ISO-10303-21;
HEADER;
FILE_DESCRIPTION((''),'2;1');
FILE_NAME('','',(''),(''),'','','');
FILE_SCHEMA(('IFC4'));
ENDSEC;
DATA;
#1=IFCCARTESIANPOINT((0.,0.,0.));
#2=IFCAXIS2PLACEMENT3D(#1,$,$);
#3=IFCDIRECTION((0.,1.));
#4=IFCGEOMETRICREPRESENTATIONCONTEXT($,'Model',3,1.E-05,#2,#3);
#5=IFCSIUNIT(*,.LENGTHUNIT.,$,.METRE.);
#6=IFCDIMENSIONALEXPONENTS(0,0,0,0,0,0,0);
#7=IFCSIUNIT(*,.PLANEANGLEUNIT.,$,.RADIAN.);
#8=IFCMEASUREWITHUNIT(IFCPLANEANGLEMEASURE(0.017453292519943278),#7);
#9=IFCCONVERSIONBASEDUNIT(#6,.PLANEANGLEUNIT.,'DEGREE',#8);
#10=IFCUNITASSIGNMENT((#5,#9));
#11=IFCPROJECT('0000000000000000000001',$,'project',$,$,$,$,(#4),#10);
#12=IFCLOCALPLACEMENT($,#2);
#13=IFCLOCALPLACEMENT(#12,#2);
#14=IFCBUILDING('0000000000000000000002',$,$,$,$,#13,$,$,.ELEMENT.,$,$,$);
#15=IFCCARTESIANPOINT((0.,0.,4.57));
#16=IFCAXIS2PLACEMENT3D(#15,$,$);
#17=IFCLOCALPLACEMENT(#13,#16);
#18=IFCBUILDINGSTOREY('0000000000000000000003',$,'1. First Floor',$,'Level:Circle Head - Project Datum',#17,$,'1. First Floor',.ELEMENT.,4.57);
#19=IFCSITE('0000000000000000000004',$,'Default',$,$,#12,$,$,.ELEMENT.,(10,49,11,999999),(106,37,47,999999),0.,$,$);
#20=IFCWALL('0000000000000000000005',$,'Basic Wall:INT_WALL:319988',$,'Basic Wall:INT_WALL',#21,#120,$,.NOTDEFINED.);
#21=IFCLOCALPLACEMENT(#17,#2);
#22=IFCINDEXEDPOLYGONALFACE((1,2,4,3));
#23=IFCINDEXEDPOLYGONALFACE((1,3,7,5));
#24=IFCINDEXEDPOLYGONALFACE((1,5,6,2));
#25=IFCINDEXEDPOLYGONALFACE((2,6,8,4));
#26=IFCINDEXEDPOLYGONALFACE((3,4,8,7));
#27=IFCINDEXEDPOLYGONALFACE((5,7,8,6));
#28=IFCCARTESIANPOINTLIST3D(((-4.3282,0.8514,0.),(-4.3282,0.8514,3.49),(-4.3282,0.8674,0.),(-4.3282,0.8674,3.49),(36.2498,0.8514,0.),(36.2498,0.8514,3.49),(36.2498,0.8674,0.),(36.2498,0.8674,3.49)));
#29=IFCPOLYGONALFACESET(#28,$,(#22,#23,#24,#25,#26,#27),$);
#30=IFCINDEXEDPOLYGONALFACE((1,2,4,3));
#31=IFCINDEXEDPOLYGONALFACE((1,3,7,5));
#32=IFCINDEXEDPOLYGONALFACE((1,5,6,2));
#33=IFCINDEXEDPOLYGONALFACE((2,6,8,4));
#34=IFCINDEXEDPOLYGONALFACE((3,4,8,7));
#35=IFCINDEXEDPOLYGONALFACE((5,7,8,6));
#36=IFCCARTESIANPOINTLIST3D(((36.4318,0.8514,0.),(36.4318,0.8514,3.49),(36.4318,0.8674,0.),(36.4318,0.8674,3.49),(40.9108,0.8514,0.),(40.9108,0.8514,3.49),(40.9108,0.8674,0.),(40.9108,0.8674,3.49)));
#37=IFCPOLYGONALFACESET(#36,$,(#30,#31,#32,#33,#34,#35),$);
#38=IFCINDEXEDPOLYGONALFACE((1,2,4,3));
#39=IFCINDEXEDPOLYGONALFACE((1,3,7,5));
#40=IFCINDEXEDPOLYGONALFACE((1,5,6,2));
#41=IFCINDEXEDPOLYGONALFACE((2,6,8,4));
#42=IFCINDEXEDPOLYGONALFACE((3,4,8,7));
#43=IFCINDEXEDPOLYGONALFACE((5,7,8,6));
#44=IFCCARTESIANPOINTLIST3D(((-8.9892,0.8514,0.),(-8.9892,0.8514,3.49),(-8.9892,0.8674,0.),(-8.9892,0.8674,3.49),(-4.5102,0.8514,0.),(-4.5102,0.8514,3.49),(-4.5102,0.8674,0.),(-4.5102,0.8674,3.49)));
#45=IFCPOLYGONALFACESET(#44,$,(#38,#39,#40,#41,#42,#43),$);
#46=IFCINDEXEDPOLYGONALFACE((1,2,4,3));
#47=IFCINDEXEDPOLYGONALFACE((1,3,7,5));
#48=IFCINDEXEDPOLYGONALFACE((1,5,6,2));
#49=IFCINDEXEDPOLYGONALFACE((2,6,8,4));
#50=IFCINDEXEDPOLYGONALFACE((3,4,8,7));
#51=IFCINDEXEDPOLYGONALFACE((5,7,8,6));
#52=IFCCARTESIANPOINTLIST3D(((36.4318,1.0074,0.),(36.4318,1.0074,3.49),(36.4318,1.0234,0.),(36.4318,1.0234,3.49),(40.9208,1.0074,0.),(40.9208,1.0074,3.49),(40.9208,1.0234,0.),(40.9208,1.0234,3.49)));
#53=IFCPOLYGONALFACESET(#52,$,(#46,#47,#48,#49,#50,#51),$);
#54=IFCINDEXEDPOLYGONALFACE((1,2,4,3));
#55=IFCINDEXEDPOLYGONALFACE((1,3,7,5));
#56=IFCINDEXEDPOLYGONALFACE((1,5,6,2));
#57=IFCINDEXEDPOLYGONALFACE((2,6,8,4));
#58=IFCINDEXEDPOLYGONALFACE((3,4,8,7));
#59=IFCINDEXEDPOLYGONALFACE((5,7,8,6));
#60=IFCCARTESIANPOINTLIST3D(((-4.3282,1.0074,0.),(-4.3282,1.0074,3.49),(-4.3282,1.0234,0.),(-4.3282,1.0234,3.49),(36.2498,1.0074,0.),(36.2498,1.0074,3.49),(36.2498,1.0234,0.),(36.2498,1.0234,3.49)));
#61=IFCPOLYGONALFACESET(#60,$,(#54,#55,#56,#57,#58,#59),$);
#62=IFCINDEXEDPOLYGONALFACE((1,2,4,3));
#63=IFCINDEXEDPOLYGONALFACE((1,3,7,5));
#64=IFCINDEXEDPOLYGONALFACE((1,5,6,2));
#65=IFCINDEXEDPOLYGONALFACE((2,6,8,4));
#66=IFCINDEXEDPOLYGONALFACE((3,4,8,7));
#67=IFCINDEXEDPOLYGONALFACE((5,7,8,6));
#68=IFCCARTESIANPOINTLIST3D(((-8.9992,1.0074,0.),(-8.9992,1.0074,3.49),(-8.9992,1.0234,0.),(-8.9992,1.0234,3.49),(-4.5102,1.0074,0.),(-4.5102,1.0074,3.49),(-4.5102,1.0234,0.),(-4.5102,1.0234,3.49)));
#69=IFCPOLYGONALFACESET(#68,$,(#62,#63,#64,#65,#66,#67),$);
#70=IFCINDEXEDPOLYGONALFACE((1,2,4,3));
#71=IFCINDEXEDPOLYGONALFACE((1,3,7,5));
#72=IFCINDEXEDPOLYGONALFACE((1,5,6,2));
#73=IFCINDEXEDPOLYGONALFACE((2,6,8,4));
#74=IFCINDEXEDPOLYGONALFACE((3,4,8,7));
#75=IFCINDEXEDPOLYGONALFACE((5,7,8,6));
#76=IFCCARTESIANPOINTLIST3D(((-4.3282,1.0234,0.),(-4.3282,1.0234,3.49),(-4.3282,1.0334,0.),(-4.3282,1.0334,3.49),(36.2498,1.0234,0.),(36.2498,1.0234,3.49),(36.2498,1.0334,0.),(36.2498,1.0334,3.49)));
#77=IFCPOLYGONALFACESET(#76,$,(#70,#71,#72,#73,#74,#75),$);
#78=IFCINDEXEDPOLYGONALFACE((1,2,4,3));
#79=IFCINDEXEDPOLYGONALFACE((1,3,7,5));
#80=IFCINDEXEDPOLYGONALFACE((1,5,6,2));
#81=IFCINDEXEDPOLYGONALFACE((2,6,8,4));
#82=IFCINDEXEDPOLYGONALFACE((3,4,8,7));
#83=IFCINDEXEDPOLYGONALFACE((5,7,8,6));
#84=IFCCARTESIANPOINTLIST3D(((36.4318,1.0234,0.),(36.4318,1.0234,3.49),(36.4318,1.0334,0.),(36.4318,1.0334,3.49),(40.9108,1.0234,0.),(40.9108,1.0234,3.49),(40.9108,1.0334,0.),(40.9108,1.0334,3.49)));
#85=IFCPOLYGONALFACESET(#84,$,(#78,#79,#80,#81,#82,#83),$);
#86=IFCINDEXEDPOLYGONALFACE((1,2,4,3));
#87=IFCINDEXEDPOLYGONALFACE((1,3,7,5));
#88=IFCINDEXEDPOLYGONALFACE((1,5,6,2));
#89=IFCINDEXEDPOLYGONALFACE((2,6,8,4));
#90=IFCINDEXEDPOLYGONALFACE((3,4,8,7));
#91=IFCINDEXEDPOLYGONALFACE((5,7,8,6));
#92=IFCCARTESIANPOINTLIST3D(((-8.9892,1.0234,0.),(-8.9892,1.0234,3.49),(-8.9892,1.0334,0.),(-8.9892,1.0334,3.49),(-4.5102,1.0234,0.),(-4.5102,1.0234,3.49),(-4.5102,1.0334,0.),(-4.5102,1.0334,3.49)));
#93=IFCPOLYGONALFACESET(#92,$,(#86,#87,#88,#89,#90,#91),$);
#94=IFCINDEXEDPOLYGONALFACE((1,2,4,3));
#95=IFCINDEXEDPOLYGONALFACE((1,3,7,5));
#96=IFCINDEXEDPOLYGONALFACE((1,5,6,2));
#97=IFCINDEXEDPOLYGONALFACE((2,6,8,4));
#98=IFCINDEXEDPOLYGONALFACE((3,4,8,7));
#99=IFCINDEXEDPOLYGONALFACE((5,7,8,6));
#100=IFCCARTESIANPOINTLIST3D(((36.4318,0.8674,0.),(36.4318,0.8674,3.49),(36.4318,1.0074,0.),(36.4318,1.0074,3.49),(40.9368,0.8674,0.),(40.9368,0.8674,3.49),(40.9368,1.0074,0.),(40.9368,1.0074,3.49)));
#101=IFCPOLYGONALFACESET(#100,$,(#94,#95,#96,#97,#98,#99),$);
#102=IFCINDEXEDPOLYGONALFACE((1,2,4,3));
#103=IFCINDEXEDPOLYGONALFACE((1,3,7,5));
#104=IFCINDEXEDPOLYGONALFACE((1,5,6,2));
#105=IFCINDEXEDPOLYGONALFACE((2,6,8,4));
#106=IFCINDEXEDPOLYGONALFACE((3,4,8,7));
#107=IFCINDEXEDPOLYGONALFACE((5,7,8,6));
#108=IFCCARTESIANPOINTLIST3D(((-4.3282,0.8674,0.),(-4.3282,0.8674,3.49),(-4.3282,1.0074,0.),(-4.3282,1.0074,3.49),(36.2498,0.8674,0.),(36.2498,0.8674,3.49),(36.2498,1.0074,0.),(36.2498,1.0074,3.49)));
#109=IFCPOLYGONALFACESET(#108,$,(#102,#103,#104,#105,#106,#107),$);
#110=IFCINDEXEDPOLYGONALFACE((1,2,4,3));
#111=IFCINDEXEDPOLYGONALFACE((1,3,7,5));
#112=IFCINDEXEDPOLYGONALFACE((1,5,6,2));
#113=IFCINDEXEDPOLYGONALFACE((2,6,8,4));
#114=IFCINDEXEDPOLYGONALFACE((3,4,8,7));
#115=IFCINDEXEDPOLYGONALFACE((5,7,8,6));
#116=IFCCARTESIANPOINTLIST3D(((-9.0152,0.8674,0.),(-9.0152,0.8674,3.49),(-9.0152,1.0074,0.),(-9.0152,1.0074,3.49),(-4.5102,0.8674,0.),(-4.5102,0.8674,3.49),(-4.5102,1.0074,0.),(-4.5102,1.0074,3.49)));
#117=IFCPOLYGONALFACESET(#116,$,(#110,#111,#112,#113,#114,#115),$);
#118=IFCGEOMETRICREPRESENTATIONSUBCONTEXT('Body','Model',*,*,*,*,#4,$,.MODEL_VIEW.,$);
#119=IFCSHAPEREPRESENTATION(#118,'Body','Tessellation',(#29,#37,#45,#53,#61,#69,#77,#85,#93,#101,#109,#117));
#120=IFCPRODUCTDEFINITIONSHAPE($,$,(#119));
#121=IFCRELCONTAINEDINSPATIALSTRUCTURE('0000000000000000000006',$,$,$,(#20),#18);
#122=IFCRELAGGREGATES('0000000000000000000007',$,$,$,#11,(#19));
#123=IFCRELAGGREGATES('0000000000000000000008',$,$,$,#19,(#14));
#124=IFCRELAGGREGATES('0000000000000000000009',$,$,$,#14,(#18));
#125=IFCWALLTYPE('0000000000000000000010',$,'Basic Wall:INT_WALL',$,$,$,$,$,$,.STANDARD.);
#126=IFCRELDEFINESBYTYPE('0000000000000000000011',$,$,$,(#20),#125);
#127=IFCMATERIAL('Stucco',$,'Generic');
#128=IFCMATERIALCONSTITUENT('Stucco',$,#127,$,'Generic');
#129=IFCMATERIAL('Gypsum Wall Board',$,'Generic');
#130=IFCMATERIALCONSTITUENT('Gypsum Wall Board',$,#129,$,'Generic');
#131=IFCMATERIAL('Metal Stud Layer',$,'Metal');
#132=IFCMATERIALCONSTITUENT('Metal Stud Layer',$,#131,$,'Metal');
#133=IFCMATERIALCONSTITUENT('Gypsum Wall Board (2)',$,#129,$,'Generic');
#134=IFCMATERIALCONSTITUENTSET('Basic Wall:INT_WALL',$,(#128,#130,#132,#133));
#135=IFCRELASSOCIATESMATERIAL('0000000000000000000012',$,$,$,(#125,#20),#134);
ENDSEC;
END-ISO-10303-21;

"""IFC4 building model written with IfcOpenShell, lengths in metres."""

from ifc_helpers import new_model, entity, si_unit, converted_unit, direction, frame, origin, place, context, subcontext, project, spatial, indexed_curve, outline, extrude, material, constituent, constituent_set, type_object, element, save


model = new_model("IFC4")

# Units and contexts
model_context = context("Model", 3, precision=1e-05, world=origin(), true_north=direction((0.0, 1.0)))
body_context = subcontext(model_context, "Body", "Model", "MODEL_VIEW")
ifc_project = project(units=[si_unit("LENGTHUNIT", "METRE"), converted_unit("PLANEANGLEUNIT", "DEGREE", entity("IfcPlaneAngleMeasure", 0.017453292519943278), si_unit("PLANEANGLEUNIT", "RADIAN"), dimensions=[0, 0, 0, 0, 0, 0, 0])], contexts=[model_context])

# Site, building, storey
site_placement = place(None, origin())
site = spatial("IfcSite", under=ifc_project, at=site_placement, Name="Default", CompositionType="ELEMENT", RefLatitude=(10, 49, 11, 999999), RefLongitude=(106, 37, 47, 999999), RefElevation=0.0)
building_placement = place(site_placement, origin())
building = spatial("IfcBuilding", under=site, at=building_placement, CompositionType="ELEMENT")
storey_placement = place(building_placement, frame((0.0, 0.0, 4.57)))
storey = spatial("IfcBuildingStorey", under=building, at=storey_placement, Name="1. First Floor", ObjectType="Level:Circle Head - Project Datum", LongName="1. First Floor", CompositionType="ELEMENT", Elevation=4.57)

# Wall
ifc_material_1 = material(Name="Stucco", Category="Generic")
ifc_constituent_1 = constituent(ifc_material_1, Name="Stucco", Category="Generic")
ifc_material_2 = material(Name="Gypsum Wall Board", Category="Generic")
ifc_constituent_2 = constituent(ifc_material_2, Name="Gypsum Wall Board", Category="Generic")
ifc_material_3 = material(Name="Metal Stud Layer", Category="Metal")
ifc_constituent_3 = constituent(ifc_material_3, Name="Metal Stud Layer", Category="Metal")
ifc_constituent_4 = constituent(ifc_material_2, Name="Gypsum Wall Board (2)", Category="Generic")
ifc_constituent_set_1 = constituent_set(constituents=[ifc_constituent_1, ifc_constituent_2, ifc_constituent_3, ifc_constituent_4], Name="Basic Wall:INT_WALL")
wall_type_1 = type_object("IfcWallType", Name="Basic Wall:INT_WALL", PredefinedType="STANDARD", material=ifc_constituent_set_1)
wall_1_placement = place(storey_placement, frame((-8.9892, 0.9424, 0.0)))
element("IfcWall", 1, at=wall_1_placement, inside=storey, type_object=wall_type_1, material=ifc_constituent_set_1, Name="Basic Wall:INT_WALL:319988", ObjectType="Basic Wall:INT_WALL", PredefinedType="NOTDEFINED", context=body_context, shape_type="SweptSolid", body=[
    extrude(outline(indexed_curve([(-0.008, -20.289), (0.008, -20.289), (0.008, 20.289), (-0.008, 20.289), (-0.008, -20.289)], self_intersect=False)), frame((24.95, -0.083, 0.0), z_axis=(0.0, 0.0, 1.0), x_axis=(0.0, 1.0, 0.0)), (0.0, 0.0, 1.0), 3.49),
    extrude(outline(indexed_curve([(-0.008, -2.2395), (0.008, -2.2395), (0.008, 2.2395), (-0.008, 2.2395), (-0.008, -2.2395)], self_intersect=False)), frame((47.6605, -0.083, 0.0), z_axis=(0.0, 0.0, 1.0), x_axis=(0.0, 1.0, 0.0)), (0.0, 0.0, 1.0), 3.49),
    extrude(outline(indexed_curve([(-0.008, -2.2395), (0.008, -2.2395), (0.008, 2.2395), (-0.008, 2.2395), (-0.008, -2.2395)], self_intersect=False)), frame((2.2395, -0.083, 0.0), z_axis=(0.0, 0.0, 1.0), x_axis=(0.0, 1.0, 0.0)), (0.0, 0.0, 1.0), 3.49),
    extrude(outline(indexed_curve([(-2.2445, -0.008), (2.2445, -0.008), (2.2445, 0.008), (-2.2445, 0.008), (-2.2445, -0.008)], self_intersect=False)), frame((47.6655, 0.073, 0.0), z_axis=(0.0, 0.0, 1.0), x_axis=(-1.0, 0.0, 0.0)), (0.0, 0.0, 1.0), 3.49),
    extrude(outline(indexed_curve([(-20.289, -0.008), (20.289, -0.008), (20.289, 0.008), (-20.289, 0.008), (-20.289, -0.008)], self_intersect=False)), frame((24.95, 0.073, 0.0)), (0.0, 0.0, 1.0), 3.49),
    extrude(outline(indexed_curve([(-2.2445, -0.008), (2.2445, -0.008), (2.2445, 0.008), (-2.2445, 0.008), (-2.2445, -0.008)], self_intersect=False)), frame((2.2345, 0.073, 0.0)), (0.0, 0.0, 1.0), 3.49),
    extrude(outline(indexed_curve([(-0.005, -20.289), (0.005, -20.289), (0.005, 20.289), (-0.005, 20.289), (-0.005, -20.289)], self_intersect=False)), frame((24.95, 0.086, 0.0), z_axis=(0.0, 0.0, 1.0), x_axis=(0.0, -1.0, 0.0)), (0.0, 0.0, 1.0), 3.49),
    extrude(outline(indexed_curve([(-0.005, -2.2395), (0.005, -2.2395), (0.005, 2.2395), (-0.005, 2.2395), (-0.005, -2.2395)], self_intersect=False)), frame((47.6605, 0.086, 0.0), z_axis=(0.0, 0.0, 1.0), x_axis=(0.0, -1.0, 0.0)), (0.0, 0.0, 1.0), 3.49),
    extrude(outline(indexed_curve([(-0.005, -2.2395), (0.005, -2.2395), (0.005, 2.2395), (-0.005, 2.2395), (-0.005, -2.2395)], self_intersect=False)), frame((2.2395, 0.086, 0.0), z_axis=(0.0, 0.0, 1.0), x_axis=(0.0, -1.0, 0.0)), (0.0, 0.0, 1.0), 3.49),
    extrude(outline(indexed_curve([(-2.2525, -0.07), (2.2525, -0.07), (2.2525, 0.07), (-2.2525, 0.07), (-2.2525, -0.07)], self_intersect=False)), frame((47.6735, -0.005, 0.0), z_axis=(0.0, 0.0, 1.0), x_axis=(-1.0, 0.0, 0.0)), (0.0, 0.0, 1.0), 3.49),
    extrude(outline(indexed_curve([(-20.289, -0.07), (20.289, -0.07), (20.289, 0.07), (-20.289, 0.07), (-20.289, -0.07)], self_intersect=False)), frame((24.95, -0.005, 0.0)), (0.0, 0.0, 1.0), 3.49),
    extrude(outline(indexed_curve([(-2.2525, -0.07), (2.2525, -0.07), (2.2525, 0.07), (-2.2525, 0.07), (-2.2525, -0.07)], self_intersect=False)), frame((2.2265, -0.005, 0.0)), (0.0, 0.0, 1.0), 3.49),
])

save(model, "model.ifc")
